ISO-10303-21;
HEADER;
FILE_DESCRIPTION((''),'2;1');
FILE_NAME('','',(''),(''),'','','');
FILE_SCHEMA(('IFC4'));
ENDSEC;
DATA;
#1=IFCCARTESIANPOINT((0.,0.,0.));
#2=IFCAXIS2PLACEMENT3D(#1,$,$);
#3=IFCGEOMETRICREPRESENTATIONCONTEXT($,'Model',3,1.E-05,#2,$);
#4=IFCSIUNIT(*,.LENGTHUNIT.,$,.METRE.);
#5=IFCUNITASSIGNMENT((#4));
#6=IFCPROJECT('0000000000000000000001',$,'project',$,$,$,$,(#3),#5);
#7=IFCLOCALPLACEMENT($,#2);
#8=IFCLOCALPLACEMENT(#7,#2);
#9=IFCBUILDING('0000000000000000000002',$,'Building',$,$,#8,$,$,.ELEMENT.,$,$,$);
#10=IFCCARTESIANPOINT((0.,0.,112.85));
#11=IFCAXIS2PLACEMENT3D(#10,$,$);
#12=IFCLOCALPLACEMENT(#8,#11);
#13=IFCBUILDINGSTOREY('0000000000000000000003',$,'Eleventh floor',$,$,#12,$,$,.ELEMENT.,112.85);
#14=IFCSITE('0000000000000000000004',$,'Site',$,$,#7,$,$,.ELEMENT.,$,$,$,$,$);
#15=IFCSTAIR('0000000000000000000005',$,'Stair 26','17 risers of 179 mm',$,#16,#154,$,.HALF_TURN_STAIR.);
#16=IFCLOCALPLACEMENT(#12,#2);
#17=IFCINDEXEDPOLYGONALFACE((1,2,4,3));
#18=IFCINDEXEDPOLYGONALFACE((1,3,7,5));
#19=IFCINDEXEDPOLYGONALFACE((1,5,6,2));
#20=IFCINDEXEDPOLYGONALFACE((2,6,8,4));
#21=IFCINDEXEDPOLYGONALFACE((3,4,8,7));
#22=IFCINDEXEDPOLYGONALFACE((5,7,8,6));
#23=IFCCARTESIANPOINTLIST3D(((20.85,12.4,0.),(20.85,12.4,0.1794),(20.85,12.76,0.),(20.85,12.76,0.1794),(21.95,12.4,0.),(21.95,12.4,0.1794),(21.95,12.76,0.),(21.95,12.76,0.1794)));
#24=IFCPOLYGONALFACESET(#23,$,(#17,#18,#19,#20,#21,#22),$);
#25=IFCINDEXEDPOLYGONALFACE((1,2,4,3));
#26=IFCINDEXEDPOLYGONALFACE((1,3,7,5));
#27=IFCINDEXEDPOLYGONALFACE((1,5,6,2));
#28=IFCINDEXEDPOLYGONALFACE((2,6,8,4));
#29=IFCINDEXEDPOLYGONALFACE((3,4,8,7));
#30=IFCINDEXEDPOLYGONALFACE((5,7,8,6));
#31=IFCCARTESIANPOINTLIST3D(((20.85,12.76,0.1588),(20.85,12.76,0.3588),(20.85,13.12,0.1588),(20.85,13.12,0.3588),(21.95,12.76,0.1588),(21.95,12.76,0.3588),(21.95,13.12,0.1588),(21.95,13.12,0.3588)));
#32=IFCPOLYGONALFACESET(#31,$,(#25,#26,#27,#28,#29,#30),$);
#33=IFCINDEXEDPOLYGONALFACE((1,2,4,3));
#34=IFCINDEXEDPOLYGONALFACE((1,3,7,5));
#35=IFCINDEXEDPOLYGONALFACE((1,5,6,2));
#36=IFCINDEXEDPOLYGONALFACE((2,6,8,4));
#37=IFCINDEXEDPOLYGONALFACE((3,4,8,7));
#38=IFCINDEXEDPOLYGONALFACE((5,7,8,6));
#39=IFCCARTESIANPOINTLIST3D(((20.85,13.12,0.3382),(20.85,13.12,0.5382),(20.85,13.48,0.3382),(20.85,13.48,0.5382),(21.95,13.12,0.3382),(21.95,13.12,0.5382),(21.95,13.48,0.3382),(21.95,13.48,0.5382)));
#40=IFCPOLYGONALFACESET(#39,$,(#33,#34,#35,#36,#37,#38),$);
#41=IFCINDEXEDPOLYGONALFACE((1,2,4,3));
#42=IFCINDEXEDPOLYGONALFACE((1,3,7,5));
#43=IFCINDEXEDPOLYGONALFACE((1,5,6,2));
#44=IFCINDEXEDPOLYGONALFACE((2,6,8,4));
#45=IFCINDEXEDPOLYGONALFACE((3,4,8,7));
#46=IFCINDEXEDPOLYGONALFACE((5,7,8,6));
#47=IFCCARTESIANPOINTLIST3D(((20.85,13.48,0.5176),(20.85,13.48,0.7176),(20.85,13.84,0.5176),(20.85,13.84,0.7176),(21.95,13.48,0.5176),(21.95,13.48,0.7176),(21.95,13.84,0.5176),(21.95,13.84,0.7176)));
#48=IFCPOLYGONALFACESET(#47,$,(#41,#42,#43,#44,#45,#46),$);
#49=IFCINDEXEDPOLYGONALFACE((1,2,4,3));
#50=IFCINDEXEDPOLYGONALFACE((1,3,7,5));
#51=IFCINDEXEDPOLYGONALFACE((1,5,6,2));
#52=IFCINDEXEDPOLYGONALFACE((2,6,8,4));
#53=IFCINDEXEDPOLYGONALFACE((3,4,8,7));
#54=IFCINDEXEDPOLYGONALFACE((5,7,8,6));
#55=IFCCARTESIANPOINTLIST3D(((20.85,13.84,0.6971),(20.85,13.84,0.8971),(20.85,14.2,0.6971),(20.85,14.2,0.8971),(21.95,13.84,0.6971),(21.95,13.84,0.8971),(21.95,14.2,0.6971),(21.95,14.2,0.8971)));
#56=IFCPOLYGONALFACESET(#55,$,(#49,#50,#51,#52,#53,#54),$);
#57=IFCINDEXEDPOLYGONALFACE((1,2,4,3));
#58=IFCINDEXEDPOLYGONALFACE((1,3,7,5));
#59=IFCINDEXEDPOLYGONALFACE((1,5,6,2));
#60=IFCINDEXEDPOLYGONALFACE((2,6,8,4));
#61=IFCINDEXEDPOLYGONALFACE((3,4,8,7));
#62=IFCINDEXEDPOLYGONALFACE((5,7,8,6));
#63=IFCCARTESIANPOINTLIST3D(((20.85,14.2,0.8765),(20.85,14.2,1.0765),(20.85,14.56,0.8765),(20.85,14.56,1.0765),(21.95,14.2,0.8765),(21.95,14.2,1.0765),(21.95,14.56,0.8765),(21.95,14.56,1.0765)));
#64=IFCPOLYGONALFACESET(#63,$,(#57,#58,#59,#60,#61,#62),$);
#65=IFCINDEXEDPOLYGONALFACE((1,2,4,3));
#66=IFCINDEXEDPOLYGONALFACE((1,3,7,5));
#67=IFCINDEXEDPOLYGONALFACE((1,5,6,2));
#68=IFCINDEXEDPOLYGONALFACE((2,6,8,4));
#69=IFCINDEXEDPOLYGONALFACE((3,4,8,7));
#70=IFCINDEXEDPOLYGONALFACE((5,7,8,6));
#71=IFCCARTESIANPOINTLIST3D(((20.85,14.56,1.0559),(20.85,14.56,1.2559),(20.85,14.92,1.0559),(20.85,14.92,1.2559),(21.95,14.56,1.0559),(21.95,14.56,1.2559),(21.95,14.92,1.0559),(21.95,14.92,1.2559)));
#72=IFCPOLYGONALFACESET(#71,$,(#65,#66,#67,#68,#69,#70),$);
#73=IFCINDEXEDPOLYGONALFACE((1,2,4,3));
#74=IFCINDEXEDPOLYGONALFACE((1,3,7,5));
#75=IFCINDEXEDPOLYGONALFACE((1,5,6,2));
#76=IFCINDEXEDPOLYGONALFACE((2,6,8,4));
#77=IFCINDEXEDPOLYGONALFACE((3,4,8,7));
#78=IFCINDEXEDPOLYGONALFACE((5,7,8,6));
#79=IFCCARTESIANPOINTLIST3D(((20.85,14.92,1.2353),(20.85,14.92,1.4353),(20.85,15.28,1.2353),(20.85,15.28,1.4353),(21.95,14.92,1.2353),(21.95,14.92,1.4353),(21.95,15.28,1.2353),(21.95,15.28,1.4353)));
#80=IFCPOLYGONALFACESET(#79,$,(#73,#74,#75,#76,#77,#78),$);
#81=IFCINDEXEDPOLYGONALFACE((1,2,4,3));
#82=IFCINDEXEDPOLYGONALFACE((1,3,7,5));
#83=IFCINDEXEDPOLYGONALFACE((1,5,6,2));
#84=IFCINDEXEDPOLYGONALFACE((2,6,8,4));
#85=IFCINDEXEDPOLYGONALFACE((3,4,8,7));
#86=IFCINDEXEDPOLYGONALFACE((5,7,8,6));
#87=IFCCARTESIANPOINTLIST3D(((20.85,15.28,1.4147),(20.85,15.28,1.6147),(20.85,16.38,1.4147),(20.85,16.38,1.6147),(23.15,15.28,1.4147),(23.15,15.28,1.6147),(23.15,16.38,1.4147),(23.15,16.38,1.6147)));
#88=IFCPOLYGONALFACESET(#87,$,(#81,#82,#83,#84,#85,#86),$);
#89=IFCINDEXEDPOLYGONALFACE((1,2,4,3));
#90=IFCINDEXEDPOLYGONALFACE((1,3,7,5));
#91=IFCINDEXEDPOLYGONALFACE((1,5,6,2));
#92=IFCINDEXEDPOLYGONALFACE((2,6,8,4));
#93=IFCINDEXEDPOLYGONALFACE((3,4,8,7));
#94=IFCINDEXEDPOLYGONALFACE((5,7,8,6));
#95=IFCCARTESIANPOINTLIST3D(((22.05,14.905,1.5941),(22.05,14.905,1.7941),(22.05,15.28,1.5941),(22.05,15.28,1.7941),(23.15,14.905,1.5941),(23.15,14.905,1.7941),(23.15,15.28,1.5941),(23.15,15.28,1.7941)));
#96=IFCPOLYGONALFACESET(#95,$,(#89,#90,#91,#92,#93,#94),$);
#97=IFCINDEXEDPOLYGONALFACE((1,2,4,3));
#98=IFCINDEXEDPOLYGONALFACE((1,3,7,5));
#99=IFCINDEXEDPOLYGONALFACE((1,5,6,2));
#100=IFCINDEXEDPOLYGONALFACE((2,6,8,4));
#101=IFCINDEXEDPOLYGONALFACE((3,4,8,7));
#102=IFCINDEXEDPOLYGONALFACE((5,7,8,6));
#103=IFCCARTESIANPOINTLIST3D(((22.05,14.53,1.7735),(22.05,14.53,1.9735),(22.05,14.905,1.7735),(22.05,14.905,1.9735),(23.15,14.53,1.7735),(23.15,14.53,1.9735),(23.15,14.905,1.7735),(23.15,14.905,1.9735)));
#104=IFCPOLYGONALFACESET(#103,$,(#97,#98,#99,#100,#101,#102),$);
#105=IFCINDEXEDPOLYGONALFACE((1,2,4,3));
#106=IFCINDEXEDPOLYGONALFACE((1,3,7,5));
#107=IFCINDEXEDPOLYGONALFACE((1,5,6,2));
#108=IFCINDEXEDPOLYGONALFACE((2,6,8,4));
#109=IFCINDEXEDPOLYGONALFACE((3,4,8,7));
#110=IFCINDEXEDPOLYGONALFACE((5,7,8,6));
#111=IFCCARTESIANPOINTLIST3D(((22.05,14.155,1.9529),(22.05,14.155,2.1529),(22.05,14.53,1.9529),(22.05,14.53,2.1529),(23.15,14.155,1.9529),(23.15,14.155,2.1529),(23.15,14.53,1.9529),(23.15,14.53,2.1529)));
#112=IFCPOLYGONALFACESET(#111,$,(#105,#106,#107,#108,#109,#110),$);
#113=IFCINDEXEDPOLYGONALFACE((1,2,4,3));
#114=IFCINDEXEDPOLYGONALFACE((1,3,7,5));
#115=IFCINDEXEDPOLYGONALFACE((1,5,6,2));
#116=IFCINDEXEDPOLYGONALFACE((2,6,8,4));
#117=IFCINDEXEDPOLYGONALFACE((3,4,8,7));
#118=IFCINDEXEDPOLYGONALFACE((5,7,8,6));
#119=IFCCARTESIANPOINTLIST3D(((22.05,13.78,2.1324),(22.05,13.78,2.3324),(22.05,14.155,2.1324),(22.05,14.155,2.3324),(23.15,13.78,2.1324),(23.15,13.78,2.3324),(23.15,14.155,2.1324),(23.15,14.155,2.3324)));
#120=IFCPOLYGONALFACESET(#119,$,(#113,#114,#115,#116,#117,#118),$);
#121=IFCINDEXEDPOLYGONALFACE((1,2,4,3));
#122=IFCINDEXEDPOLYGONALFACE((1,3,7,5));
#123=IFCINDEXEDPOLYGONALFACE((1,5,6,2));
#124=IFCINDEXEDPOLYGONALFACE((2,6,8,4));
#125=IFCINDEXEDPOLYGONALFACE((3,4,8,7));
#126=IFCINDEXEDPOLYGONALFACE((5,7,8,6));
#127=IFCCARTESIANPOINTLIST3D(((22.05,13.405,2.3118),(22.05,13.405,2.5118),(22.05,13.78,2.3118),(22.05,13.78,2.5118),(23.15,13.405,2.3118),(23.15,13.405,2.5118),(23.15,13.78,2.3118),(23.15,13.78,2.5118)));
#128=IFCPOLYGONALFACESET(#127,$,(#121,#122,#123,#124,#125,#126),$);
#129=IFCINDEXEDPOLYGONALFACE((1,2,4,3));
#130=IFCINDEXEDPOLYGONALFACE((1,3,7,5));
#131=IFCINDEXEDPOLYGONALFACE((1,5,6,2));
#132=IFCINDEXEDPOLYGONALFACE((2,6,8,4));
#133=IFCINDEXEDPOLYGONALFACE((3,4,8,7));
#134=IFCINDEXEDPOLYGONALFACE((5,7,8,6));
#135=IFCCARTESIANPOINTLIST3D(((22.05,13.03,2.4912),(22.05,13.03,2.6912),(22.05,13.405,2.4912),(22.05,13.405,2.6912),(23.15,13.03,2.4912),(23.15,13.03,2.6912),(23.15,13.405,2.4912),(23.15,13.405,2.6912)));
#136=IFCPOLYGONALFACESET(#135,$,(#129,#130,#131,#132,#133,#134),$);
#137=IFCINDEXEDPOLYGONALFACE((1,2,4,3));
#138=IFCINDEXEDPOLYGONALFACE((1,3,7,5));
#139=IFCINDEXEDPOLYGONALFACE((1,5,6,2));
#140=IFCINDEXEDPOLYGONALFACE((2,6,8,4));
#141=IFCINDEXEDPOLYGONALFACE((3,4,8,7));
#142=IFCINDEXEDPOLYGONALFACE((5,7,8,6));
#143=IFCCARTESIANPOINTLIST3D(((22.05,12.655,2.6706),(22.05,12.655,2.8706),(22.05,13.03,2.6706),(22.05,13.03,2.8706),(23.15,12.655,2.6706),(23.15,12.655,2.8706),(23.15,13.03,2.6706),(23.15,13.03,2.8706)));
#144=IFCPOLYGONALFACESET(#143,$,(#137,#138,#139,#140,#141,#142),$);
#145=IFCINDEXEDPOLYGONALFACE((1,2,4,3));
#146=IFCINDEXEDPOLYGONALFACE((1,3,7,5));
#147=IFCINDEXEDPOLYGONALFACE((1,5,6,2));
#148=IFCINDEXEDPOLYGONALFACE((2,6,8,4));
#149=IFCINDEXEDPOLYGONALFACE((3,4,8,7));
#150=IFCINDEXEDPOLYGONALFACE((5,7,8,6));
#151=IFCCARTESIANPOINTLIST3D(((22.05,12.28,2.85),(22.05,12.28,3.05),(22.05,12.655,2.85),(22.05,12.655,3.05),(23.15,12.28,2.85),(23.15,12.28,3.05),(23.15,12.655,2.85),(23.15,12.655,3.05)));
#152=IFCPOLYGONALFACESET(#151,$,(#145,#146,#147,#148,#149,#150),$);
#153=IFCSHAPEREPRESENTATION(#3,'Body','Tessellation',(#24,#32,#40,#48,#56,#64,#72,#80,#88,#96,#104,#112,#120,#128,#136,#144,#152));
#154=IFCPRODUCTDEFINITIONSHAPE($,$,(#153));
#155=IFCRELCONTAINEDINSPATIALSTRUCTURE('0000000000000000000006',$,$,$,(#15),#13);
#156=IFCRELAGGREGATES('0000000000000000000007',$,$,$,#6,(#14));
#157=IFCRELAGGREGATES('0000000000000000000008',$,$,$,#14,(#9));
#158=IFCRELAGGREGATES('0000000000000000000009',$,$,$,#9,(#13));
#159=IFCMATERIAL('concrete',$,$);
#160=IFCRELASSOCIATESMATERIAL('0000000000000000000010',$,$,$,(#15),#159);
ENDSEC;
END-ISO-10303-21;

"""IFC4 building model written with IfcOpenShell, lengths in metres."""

from ifc_helpers import new_model, si_unit, frame, origin, place, context, project, spatial, polyline, outline, extrude, material, element, save


model = new_model("IFC4")

# Units and contexts
model_context = context("Model", 3, precision=1e-05, world=origin())
ifc_project = project(units=[si_unit("LENGTHUNIT", "METRE")], contexts=[model_context])

# Site, building, storey
site_placement = place(None, origin())
site = spatial("IfcSite", under=ifc_project, at=site_placement, Name="Site", CompositionType="ELEMENT")
building_placement = place(site_placement, origin())
building = spatial("IfcBuilding", under=site, at=building_placement, Name="Building", CompositionType="ELEMENT")
storey_placement = place(building_placement, frame((0.0, 0.0, 112.85)))
storey = spatial("IfcBuildingStorey", under=building, at=storey_placement, Name="Eleventh floor", CompositionType="ELEMENT", Elevation=112.85)

# Shared definitions
ifc_material = material(Name="concrete")

# Stair
stair_1_placement = place(storey_placement, frame((21.4, 12.4, 0.0), z_axis=(0.0, 0.0, 1.0), x_axis=(0.0, 1.0, 0.0)))
element("IfcStair", 1, at=stair_1_placement, inside=storey, material=ifc_material, Name="Stair 26", Description="17 risers of 179 mm", PredefinedType="HALF_TURN_STAIR", context=model_context, shape_type="SweptSolid", body=[
    extrude(outline(polyline([(0.0, -0.55), (0.36, -0.55), (0.36, 0.55), (0.0, 0.55), (0.0, -0.55)])), origin(), (0.0, 0.0, 1.0), 0.1794),
    extrude(outline(polyline([(0.36, -0.55), (0.72, -0.55), (0.72, 0.55), (0.36, 0.55), (0.36, -0.55)])), frame((0.0, 0.0, 0.1588)), (0.0, 0.0, 1.0), 0.2),
    extrude(outline(polyline([(0.72, -0.55), (1.08, -0.55), (1.08, 0.55), (0.72, 0.55), (0.72, -0.55)])), frame((0.0, 0.0, 0.3382)), (0.0, 0.0, 1.0), 0.2),
    extrude(outline(polyline([(1.08, -0.55), (1.44, -0.55), (1.44, 0.55), (1.08, 0.55), (1.08, -0.55)])), frame((0.0, 0.0, 0.5176)), (0.0, 0.0, 1.0), 0.2),
    extrude(outline(polyline([(1.44, -0.55), (1.8, -0.55), (1.8, 0.55), (1.44, 0.55), (1.44, -0.55)])), frame((0.0, 0.0, 0.6971)), (0.0, 0.0, 1.0), 0.2),
    extrude(outline(polyline([(1.8, -0.55), (2.16, -0.55), (2.16, 0.55), (1.8, 0.55), (1.8, -0.55)])), frame((0.0, 0.0, 0.8765)), (0.0, 0.0, 1.0), 0.2),
    extrude(outline(polyline([(2.16, -0.55), (2.52, -0.55), (2.52, 0.55), (2.16, 0.55), (2.16, -0.55)])), frame((0.0, 0.0, 1.0559)), (0.0, 0.0, 1.0), 0.2),
    extrude(outline(polyline([(2.52, -0.55), (2.88, -0.55), (2.88, 0.55), (2.52, 0.55), (2.52, -0.55)])), frame((0.0, 0.0, 1.2353)), (0.0, 0.0, 1.0), 0.2),
    extrude(outline(polyline([(2.88, -1.75), (3.98, -1.75), (3.98, 0.55), (2.88, 0.55), (2.88, -1.75)])), frame((0.0, 0.0, 1.4147)), (0.0, 0.0, 1.0), 0.2),
    extrude(outline(polyline([(2.505, -1.75), (2.88, -1.75), (2.88, -0.65), (2.505, -0.65), (2.505, -1.75)])), frame((0.0, 0.0, 1.5941)), (0.0, 0.0, 1.0), 0.2),
    extrude(outline(polyline([(2.13, -1.75), (2.505, -1.75), (2.505, -0.65), (2.13, -0.65), (2.13, -1.75)])), frame((0.0, 0.0, 1.7735)), (0.0, 0.0, 1.0), 0.2),
    extrude(outline(polyline([(1.755, -1.75), (2.13, -1.75), (2.13, -0.65), (1.755, -0.65), (1.755, -1.75)])), frame((0.0, 0.0, 1.9529)), (0.0, 0.0, 1.0), 0.2),
    extrude(outline(polyline([(1.38, -1.75), (1.755, -1.75), (1.755, -0.65), (1.38, -0.65), (1.38, -1.75)])), frame((0.0, 0.0, 2.1324)), (0.0, 0.0, 1.0), 0.2),
    extrude(outline(polyline([(1.005, -1.75), (1.38, -1.75), (1.38, -0.65), (1.005, -0.65), (1.005, -1.75)])), frame((0.0, 0.0, 2.3118)), (0.0, 0.0, 1.0), 0.2),
    extrude(outline(polyline([(0.63, -1.75), (1.005, -1.75), (1.005, -0.65), (0.63, -0.65), (0.63, -1.75)])), frame((0.0, 0.0, 2.4912)), (0.0, 0.0, 1.0), 0.2),
    extrude(outline(polyline([(0.255, -1.75), (0.63, -1.75), (0.63, -0.65), (0.255, -0.65), (0.255, -1.75)])), frame((0.0, 0.0, 2.6706)), (0.0, 0.0, 1.0), 0.2),
    extrude(outline(polyline([(-0.12, -1.75), (0.255, -1.75), (0.255, -0.65), (-0.12, -0.65), (-0.12, -1.75)])), frame((0.0, 0.0, 2.85)), (0.0, 0.0, 1.0), 0.2),
])

save(model, "model.ifc")
